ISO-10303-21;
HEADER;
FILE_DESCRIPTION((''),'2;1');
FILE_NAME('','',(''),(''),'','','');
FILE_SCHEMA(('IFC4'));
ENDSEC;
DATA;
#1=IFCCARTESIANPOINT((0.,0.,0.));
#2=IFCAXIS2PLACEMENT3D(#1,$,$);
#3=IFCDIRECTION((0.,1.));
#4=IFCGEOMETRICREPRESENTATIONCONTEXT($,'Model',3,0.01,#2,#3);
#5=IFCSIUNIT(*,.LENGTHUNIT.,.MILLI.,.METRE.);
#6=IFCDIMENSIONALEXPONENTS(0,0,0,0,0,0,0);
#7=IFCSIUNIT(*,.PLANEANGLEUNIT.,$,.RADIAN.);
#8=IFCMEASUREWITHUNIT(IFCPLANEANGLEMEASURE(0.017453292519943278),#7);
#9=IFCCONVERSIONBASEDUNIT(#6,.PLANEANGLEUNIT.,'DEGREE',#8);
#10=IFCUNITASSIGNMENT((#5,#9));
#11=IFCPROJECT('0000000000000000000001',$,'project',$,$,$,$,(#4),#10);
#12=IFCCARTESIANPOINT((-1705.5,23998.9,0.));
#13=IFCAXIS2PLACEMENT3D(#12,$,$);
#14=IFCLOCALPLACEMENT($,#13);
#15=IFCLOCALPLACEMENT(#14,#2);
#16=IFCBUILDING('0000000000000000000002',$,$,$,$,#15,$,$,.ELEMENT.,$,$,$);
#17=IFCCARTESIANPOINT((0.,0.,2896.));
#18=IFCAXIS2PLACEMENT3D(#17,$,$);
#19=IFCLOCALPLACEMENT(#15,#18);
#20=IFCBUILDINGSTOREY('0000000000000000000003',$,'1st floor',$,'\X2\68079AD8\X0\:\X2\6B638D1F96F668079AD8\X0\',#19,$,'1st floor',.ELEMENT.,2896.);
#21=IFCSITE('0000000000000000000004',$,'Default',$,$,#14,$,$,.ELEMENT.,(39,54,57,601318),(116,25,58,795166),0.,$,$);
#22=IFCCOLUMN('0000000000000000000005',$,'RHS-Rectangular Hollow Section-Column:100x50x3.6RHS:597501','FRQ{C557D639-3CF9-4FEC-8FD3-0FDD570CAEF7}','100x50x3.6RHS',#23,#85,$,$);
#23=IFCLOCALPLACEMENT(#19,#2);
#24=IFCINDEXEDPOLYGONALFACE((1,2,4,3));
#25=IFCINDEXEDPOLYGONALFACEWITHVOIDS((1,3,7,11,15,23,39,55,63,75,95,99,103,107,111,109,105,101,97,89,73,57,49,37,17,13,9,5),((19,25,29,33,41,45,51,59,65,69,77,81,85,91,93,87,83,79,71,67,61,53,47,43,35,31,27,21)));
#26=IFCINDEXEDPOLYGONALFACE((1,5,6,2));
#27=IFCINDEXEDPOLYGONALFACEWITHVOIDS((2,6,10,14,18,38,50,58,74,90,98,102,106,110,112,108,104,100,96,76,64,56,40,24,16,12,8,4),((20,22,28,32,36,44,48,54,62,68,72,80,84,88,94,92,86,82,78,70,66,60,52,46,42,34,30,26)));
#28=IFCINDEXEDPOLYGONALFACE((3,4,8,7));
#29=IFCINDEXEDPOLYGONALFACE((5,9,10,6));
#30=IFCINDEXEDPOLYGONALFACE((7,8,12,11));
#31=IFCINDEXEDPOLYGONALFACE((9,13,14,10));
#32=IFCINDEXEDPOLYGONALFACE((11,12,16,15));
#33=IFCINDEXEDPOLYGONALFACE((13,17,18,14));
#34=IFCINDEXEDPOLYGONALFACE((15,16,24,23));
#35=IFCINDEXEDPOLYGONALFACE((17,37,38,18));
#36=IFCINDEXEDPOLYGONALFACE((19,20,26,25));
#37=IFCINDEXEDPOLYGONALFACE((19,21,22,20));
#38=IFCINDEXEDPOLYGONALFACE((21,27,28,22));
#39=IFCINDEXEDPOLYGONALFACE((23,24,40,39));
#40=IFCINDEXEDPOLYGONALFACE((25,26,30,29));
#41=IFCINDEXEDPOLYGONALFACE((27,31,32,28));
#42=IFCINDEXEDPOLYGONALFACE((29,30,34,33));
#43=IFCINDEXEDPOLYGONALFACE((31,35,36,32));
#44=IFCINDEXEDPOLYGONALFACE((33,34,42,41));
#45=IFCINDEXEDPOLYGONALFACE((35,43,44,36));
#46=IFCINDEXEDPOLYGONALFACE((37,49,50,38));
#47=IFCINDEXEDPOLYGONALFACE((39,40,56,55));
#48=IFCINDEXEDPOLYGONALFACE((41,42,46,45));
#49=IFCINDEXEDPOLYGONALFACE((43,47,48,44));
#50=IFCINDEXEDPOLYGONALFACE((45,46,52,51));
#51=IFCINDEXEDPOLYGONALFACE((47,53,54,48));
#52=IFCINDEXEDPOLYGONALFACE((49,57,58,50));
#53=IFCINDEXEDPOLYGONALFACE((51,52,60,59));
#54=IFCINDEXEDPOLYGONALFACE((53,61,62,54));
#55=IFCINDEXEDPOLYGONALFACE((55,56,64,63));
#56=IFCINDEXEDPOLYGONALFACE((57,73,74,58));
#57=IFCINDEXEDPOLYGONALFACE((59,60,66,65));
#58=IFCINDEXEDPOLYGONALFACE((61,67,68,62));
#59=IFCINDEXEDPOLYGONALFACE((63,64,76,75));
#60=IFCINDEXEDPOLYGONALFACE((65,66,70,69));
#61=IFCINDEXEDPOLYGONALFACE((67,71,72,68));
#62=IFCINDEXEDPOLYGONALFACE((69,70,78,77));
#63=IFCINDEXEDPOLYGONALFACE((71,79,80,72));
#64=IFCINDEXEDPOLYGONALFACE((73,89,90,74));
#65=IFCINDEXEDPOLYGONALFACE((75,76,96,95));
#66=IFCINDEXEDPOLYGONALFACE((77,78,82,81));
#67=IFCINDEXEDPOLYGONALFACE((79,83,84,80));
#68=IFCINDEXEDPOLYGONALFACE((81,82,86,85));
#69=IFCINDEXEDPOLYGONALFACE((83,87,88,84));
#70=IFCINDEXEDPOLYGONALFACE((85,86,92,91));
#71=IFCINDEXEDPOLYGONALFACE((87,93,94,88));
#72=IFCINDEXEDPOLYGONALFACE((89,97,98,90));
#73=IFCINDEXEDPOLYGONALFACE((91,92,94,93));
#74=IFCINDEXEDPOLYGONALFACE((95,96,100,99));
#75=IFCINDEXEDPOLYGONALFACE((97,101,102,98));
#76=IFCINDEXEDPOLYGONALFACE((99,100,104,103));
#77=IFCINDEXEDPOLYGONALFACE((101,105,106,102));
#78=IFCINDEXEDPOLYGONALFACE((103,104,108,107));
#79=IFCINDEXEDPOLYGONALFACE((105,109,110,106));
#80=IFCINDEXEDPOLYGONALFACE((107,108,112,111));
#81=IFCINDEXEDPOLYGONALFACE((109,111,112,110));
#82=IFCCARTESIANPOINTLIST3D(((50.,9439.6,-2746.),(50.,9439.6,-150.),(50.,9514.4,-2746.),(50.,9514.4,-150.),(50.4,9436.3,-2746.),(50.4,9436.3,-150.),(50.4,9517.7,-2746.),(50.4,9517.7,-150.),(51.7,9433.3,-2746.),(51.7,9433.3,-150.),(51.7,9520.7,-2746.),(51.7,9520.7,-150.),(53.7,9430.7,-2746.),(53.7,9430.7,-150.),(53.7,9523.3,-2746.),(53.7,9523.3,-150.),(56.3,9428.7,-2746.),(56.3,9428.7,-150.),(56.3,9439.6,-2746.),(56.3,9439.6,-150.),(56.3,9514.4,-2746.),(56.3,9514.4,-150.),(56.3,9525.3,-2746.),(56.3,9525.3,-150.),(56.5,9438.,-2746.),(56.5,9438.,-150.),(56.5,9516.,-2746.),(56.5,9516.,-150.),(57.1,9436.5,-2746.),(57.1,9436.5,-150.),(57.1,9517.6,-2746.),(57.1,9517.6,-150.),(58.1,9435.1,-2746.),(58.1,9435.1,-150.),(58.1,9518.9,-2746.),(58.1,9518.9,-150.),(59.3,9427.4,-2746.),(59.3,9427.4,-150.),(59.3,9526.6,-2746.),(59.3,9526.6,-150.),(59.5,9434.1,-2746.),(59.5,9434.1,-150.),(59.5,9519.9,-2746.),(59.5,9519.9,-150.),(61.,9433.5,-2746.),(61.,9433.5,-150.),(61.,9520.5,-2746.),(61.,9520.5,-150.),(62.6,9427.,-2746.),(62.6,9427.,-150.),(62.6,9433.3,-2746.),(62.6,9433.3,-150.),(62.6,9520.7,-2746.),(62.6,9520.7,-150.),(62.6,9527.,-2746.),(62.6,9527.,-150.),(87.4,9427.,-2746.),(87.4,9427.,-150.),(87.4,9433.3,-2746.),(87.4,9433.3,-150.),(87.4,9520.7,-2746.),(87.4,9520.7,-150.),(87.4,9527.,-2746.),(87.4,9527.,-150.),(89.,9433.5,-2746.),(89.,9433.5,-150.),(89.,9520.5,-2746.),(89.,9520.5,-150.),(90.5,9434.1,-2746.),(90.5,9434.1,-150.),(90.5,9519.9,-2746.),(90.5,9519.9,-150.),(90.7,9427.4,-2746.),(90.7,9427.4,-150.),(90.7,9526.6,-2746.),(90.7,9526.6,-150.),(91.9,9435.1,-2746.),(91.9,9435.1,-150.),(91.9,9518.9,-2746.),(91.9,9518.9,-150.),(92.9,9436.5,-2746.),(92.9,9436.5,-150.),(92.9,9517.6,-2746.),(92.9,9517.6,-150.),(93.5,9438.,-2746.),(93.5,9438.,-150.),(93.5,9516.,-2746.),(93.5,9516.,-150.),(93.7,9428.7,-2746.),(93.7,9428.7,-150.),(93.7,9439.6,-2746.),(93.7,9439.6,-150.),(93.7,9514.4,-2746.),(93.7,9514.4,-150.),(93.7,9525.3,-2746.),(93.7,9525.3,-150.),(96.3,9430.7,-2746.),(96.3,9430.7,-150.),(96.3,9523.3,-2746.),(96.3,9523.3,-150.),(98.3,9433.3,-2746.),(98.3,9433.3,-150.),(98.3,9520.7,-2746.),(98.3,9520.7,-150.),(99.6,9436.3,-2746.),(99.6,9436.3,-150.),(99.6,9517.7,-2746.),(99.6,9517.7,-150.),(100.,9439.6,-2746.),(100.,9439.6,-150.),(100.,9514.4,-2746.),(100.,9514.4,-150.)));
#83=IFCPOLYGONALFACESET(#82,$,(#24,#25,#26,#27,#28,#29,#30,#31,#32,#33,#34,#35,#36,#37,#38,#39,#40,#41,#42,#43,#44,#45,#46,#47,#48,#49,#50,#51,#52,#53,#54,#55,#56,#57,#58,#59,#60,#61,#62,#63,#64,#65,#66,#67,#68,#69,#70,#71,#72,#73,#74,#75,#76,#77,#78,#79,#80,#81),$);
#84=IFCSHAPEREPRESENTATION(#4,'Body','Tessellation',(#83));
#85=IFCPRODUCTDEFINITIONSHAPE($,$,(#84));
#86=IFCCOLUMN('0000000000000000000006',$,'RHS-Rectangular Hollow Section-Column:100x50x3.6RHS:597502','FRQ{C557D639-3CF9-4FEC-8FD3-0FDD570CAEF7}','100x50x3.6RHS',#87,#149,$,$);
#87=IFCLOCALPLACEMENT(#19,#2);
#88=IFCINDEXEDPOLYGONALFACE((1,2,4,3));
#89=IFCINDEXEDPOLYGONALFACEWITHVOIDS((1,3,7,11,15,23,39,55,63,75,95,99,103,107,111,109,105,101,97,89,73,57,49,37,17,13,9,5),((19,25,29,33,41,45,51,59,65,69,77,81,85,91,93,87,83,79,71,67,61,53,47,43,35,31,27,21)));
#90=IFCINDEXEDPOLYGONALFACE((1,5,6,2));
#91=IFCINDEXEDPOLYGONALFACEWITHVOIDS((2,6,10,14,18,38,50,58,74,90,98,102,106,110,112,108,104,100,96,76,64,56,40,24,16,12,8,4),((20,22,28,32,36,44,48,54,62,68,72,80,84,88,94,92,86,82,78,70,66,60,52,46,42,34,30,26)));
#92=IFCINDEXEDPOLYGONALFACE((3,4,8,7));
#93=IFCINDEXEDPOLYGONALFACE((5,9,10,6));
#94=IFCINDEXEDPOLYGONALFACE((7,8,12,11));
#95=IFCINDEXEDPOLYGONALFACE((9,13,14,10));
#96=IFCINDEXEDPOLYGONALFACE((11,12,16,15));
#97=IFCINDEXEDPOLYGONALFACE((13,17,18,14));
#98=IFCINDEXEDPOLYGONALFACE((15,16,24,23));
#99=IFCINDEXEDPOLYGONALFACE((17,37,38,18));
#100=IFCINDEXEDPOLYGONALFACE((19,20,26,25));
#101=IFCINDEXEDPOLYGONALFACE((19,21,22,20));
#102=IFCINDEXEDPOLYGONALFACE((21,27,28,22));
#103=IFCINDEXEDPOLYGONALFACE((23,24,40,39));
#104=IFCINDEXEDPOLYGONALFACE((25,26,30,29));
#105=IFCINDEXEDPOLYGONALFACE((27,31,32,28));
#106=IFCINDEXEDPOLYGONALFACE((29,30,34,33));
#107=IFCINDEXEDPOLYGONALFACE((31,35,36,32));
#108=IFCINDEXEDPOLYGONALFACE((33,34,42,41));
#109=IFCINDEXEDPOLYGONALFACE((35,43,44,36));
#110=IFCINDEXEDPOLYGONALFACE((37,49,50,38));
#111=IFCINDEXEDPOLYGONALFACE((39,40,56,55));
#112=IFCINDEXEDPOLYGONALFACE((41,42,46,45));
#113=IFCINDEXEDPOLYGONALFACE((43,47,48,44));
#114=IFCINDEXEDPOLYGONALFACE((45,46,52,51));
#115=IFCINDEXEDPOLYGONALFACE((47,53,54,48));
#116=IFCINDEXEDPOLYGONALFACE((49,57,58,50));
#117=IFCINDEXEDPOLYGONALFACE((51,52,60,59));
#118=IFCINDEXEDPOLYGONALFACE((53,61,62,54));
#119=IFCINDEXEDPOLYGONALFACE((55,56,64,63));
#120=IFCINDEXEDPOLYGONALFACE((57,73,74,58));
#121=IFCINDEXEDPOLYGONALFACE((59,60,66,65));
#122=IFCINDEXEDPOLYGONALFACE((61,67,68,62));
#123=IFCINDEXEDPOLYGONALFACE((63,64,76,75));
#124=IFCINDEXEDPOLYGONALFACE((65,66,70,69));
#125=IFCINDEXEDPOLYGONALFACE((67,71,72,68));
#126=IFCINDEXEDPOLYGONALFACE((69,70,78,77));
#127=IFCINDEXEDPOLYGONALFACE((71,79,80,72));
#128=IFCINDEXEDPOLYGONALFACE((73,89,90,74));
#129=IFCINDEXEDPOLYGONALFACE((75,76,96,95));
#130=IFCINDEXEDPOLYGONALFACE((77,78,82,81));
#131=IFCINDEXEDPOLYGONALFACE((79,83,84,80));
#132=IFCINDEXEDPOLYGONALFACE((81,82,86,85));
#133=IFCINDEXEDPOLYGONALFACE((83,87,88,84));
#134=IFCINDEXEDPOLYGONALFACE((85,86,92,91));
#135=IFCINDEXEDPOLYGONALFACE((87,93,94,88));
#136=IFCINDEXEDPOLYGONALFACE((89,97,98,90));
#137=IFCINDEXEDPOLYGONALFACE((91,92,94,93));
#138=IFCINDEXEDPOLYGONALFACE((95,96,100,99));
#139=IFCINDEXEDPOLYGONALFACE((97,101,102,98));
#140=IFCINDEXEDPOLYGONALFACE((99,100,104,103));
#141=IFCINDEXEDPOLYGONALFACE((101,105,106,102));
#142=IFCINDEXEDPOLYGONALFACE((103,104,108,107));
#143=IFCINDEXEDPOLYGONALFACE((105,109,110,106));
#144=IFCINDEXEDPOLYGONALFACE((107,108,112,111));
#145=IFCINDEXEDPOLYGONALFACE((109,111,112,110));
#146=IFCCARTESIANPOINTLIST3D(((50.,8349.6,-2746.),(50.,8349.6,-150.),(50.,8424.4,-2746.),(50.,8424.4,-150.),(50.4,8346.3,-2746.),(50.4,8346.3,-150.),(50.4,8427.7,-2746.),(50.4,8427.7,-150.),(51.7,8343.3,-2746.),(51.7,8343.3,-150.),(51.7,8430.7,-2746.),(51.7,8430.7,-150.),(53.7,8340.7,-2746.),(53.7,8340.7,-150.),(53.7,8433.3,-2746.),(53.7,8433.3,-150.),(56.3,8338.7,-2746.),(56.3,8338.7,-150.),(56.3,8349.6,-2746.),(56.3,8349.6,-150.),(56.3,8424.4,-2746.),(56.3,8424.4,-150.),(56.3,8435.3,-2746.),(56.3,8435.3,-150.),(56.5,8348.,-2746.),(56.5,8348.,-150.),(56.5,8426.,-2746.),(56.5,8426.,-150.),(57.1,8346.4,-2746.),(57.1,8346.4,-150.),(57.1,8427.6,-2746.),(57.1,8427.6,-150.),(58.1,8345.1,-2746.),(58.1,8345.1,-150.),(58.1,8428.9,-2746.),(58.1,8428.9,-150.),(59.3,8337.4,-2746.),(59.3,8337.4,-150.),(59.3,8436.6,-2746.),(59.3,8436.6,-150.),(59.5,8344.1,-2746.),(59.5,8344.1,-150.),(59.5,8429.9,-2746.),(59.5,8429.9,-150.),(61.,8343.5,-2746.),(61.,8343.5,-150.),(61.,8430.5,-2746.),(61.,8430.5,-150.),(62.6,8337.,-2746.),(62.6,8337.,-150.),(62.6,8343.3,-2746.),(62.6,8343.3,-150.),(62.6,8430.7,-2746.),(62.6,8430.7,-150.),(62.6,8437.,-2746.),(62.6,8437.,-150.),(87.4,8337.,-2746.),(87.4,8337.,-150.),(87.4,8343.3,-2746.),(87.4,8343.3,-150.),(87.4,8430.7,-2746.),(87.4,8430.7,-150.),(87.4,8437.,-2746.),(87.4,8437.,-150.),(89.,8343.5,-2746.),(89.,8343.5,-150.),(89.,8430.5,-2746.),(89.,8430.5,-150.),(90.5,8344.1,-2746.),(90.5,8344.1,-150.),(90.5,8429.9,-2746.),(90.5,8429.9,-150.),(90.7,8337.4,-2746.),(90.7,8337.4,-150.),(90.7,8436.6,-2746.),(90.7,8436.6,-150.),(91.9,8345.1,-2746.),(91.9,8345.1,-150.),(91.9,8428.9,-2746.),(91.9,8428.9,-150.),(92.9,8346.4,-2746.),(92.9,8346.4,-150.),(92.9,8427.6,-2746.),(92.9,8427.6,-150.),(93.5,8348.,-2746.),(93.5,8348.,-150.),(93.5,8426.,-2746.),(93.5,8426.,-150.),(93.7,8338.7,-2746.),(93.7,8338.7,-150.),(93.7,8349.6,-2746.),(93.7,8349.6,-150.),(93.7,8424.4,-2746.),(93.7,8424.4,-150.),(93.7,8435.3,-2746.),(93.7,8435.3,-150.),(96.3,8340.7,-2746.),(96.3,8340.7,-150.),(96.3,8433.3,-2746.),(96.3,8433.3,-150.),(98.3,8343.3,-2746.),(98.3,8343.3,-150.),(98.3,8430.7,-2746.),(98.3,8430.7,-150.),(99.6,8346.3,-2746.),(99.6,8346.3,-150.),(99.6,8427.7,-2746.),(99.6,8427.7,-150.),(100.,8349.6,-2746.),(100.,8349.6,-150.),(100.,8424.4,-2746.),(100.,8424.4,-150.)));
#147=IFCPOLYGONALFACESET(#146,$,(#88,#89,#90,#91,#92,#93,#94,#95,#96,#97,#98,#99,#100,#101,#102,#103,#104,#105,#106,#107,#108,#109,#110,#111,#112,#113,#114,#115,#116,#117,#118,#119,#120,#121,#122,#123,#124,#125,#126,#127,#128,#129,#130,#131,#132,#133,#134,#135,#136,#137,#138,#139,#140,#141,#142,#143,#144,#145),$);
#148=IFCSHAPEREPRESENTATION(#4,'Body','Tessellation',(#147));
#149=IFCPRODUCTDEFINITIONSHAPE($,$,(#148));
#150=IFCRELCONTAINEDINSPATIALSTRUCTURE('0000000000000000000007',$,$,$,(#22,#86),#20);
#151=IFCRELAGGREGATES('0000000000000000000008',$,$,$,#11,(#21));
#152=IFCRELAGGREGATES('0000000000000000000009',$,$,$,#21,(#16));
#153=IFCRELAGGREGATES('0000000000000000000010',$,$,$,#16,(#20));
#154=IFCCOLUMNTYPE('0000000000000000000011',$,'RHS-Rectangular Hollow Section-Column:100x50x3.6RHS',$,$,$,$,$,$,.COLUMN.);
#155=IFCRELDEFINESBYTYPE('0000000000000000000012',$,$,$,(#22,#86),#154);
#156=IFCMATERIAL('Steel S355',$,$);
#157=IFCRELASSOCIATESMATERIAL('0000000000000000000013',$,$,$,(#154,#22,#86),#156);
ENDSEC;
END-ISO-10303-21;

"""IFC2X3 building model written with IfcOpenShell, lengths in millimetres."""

from ifc_helpers import new_model, entity, si_unit, converted_unit, point, direction, frame, frame_2d, origin, origin_2d, place, context, project, spatial, circle_curve, line_curve, trimmed, segment, composite_curve, hollow_rectangle, outline, extrude, clip, halfspace, material, type_object, element, save


model = new_model("IFC2X3")

# Units and contexts
model_context = context("Model", 3, precision=0.01, world=origin(), true_north=direction((0.0, 1.0)))
ifc_project = project(units=[si_unit("LENGTHUNIT", "METRE", prefix="MILLI"), converted_unit("PLANEANGLEUNIT", "DEGREE", entity("IfcPlaneAngleMeasure", 0.017453292519943278), si_unit("PLANEANGLEUNIT", "RADIAN"), dimensions=[0, 0, 0, 0, 0, 0, 0])], contexts=[model_context])

# Site, building, storey
site_placement = place(None, frame((-1705.5, 23998.9, 0.0)))
site = spatial("IfcSite", under=ifc_project, at=site_placement, Name="Default", CompositionType="ELEMENT", RefLatitude=(39, 54, 57, 601318), RefLongitude=(116, 25, 58, 795166), RefElevation=0.0)
building_placement = place(site_placement, origin())
building = spatial("IfcBuilding", under=site, at=building_placement, CompositionType="ELEMENT")
storey_placement = place(building_placement, frame((0.0, 0.0, 2896.0)))
storey = spatial("IfcBuildingStorey", under=building, at=storey_placement, Name="1st floor", ObjectType="标高:正负零标高", LongName="1st floor", CompositionType="ELEMENT", Elevation=2896.0)

# Shared definitions
ifc_material_1 = material(Name="Steel S355")

# Columns, openings
column_type_1 = type_object("IfcColumnType", Name="RHS-Rectangular Hollow Section-Column:100x50x3.6RHS", PredefinedType="COLUMN", material=ifc_material_1)
column_1_placement = place(storey_placement, frame((75.0, 9477.0, -19.1)))
column_1 = element("IfcColumn", 1, at=column_1_placement, inside=storey, type_object=column_type_1, material=ifc_material_1, Name="RHS-Rectangular Hollow Section-Column:100x50x3.6RHS:597501", Description="FRQ{C557D639-3CF9-4FEC-8FD3-0FDD570CAEF7}", ObjectType="100x50x3.6RHS", context=model_context, shape_type="Clipping", body=[
    clip(clip(extrude(hollow_rectangle(XDim=50.0, YDim=100.0, WallThickness=6.3, InnerFilletRadius=6.3, OuterFilletRadius=12.6, at=origin_2d()), origin(), (0.0, 0.0, -1.0), 2782.8), halfspace(frame((-75.0, -9477.0, -55.9), z_axis=(0.0, 0.0, -1.0), x_axis=(-1.0, 0.0, 0.0)), True)), halfspace(frame((-75.0, -9477.0, -2726.9), z_axis=(0.0, 0.0, 1.0), x_axis=(1.0, 0.0, 0.0)), True)),
])
opening_1_placement = place(column_1_placement, frame((0.0, -150.1, -130.9), z_axis=(0.0, 1.0, 0.0), x_axis=(-1.0, 0.0, 0.0)))
element("IfcOpeningElement", 2, at=opening_1_placement, cuts=column_1, ObjectType="Opening", context=model_context, shape_type="SweptSolid", body=[
    extrude(outline(composite_curve([segment(trimmed(circle_curve(frame_2d((43.0, 32.0), x_axis=(1.0, 0.0)), 32.0), [point((43.0, 0.0))], [point((75.0, 32.0))], True, "CARTESIAN"), True, "CONTINUOUS"), segment(trimmed(line_curve((75.0, 32.0), (0.0, 1.0), 86.0), [point((75.0, 32.0))], [point((75.0, 118.0))], True, "CARTESIAN"), True, "CONTINUOUS"), segment(trimmed(circle_curve(frame_2d((43.0, 118.0), x_axis=(1.0, 0.0)), 32.0), [point((75.0, 118.0))], [point((43.0, 150.0))], True, "CARTESIAN"), True, "CONTINUOUS"), segment(trimmed(line_curve((43.0, 150.0), (-1.0, 0.0), 86.0), [point((43.0, 150.0))], [point((-43.0, 150.0))], True, "CARTESIAN"), True, "CONTINUOUS"), segment(trimmed(circle_curve(frame_2d((-43.0, 118.0), x_axis=(1.0, 0.0)), 32.0), [point((-43.0, 150.0))], [point((-75.0, 118.0))], True, "CARTESIAN"), True, "CONTINUOUS"), segment(trimmed(line_curve((-75.0, 118.0), (0.0, -1.0), 86.0), [point((-75.0, 118.0))], [point((-75.0, 32.0))], True, "CARTESIAN"), True, "CONTINUOUS"), segment(trimmed(circle_curve(frame_2d((-43.0, 32.0), x_axis=(1.0, 0.0)), 32.0), [point((-75.0, 32.0))], [point((-43.0, 0.0))], True, "CARTESIAN"), True, "CONTINUOUS"), segment(trimmed(line_curve((-43.0, 0.0), (1.0, 0.0), 86.0), [point((-43.0, 0.0))], [point((43.0, 0.0))], True, "CARTESIAN"), True, "CONTINUOUS")], self_intersect="UNKNOWN")), origin(), (0.0, 0.0, 1.0), 300.2),
])
column_2_placement = place(storey_placement, frame((75.0, 8387.0, -19.1)))
column_2 = element("IfcColumn", 3, at=column_2_placement, inside=storey, type_object=column_type_1, material=ifc_material_1, Name="RHS-Rectangular Hollow Section-Column:100x50x3.6RHS:597502", Description="FRQ{C557D639-3CF9-4FEC-8FD3-0FDD570CAEF7}", ObjectType="100x50x3.6RHS", context=model_context, shape_type="Clipping", body=[
    clip(clip(extrude(hollow_rectangle(XDim=50.0, YDim=100.0, WallThickness=6.3, InnerFilletRadius=6.3, OuterFilletRadius=12.6, at=origin_2d()), origin(), (0.0, 0.0, -1.0), 2782.8), halfspace(frame((-75.0, -8387.0, -2726.9), z_axis=(0.0, 0.0, 1.0), x_axis=(1.0, 0.0, 0.0)), True)), halfspace(frame((-75.0, -8387.0, -55.9), z_axis=(0.0, 0.0, -1.0), x_axis=(-1.0, 0.0, 0.0)), True)),
])
opening_2_placement = place(column_2_placement, frame((0.0, -150.1, -130.9), z_axis=(0.0, 1.0, 0.0), x_axis=(-1.0, 0.0, 0.0)))
element("IfcOpeningElement", 4, at=opening_2_placement, cuts=column_2, ObjectType="Opening", context=model_context, shape_type="SweptSolid", body=[
    extrude(outline(composite_curve([segment(trimmed(circle_curve(frame_2d((43.0, 32.0), x_axis=(1.0, 0.0)), 32.0), [point((43.0, 0.0))], [point((75.0, 32.0))], True, "CARTESIAN"), True, "CONTINUOUS"), segment(trimmed(line_curve((75.0, 32.0), (0.0, 1.0), 86.0), [point((75.0, 32.0))], [point((75.0, 118.0))], True, "CARTESIAN"), True, "CONTINUOUS"), segment(trimmed(circle_curve(frame_2d((43.0, 118.0), x_axis=(1.0, 0.0)), 32.0), [point((75.0, 118.0))], [point((43.0, 150.0))], True, "CARTESIAN"), True, "CONTINUOUS"), segment(trimmed(line_curve((43.0, 150.0), (-1.0, 0.0), 86.0), [point((43.0, 150.0))], [point((-43.0, 150.0))], True, "CARTESIAN"), True, "CONTINUOUS"), segment(trimmed(circle_curve(frame_2d((-43.0, 118.0), x_axis=(1.0, 0.0)), 32.0), [point((-43.0, 150.0))], [point((-75.0, 118.0))], True, "CARTESIAN"), True, "CONTINUOUS"), segment(trimmed(line_curve((-75.0, 118.0), (0.0, -1.0), 86.0), [point((-75.0, 118.0))], [point((-75.0, 32.0))], True, "CARTESIAN"), True, "CONTINUOUS"), segment(trimmed(circle_curve(frame_2d((-43.0, 32.0), x_axis=(1.0, 0.0)), 32.0), [point((-75.0, 32.0))], [point((-43.0, 0.0))], True, "CARTESIAN"), True, "CONTINUOUS"), segment(trimmed(line_curve((-43.0, 0.0), (1.0, 0.0), 86.0), [point((-43.0, 0.0))], [point((43.0, 0.0))], True, "CARTESIAN"), True, "CONTINUOUS")], self_intersect="UNKNOWN")), origin(), (0.0, 0.0, 1.0), 300.2),
])

save(model, "model.ifc")
